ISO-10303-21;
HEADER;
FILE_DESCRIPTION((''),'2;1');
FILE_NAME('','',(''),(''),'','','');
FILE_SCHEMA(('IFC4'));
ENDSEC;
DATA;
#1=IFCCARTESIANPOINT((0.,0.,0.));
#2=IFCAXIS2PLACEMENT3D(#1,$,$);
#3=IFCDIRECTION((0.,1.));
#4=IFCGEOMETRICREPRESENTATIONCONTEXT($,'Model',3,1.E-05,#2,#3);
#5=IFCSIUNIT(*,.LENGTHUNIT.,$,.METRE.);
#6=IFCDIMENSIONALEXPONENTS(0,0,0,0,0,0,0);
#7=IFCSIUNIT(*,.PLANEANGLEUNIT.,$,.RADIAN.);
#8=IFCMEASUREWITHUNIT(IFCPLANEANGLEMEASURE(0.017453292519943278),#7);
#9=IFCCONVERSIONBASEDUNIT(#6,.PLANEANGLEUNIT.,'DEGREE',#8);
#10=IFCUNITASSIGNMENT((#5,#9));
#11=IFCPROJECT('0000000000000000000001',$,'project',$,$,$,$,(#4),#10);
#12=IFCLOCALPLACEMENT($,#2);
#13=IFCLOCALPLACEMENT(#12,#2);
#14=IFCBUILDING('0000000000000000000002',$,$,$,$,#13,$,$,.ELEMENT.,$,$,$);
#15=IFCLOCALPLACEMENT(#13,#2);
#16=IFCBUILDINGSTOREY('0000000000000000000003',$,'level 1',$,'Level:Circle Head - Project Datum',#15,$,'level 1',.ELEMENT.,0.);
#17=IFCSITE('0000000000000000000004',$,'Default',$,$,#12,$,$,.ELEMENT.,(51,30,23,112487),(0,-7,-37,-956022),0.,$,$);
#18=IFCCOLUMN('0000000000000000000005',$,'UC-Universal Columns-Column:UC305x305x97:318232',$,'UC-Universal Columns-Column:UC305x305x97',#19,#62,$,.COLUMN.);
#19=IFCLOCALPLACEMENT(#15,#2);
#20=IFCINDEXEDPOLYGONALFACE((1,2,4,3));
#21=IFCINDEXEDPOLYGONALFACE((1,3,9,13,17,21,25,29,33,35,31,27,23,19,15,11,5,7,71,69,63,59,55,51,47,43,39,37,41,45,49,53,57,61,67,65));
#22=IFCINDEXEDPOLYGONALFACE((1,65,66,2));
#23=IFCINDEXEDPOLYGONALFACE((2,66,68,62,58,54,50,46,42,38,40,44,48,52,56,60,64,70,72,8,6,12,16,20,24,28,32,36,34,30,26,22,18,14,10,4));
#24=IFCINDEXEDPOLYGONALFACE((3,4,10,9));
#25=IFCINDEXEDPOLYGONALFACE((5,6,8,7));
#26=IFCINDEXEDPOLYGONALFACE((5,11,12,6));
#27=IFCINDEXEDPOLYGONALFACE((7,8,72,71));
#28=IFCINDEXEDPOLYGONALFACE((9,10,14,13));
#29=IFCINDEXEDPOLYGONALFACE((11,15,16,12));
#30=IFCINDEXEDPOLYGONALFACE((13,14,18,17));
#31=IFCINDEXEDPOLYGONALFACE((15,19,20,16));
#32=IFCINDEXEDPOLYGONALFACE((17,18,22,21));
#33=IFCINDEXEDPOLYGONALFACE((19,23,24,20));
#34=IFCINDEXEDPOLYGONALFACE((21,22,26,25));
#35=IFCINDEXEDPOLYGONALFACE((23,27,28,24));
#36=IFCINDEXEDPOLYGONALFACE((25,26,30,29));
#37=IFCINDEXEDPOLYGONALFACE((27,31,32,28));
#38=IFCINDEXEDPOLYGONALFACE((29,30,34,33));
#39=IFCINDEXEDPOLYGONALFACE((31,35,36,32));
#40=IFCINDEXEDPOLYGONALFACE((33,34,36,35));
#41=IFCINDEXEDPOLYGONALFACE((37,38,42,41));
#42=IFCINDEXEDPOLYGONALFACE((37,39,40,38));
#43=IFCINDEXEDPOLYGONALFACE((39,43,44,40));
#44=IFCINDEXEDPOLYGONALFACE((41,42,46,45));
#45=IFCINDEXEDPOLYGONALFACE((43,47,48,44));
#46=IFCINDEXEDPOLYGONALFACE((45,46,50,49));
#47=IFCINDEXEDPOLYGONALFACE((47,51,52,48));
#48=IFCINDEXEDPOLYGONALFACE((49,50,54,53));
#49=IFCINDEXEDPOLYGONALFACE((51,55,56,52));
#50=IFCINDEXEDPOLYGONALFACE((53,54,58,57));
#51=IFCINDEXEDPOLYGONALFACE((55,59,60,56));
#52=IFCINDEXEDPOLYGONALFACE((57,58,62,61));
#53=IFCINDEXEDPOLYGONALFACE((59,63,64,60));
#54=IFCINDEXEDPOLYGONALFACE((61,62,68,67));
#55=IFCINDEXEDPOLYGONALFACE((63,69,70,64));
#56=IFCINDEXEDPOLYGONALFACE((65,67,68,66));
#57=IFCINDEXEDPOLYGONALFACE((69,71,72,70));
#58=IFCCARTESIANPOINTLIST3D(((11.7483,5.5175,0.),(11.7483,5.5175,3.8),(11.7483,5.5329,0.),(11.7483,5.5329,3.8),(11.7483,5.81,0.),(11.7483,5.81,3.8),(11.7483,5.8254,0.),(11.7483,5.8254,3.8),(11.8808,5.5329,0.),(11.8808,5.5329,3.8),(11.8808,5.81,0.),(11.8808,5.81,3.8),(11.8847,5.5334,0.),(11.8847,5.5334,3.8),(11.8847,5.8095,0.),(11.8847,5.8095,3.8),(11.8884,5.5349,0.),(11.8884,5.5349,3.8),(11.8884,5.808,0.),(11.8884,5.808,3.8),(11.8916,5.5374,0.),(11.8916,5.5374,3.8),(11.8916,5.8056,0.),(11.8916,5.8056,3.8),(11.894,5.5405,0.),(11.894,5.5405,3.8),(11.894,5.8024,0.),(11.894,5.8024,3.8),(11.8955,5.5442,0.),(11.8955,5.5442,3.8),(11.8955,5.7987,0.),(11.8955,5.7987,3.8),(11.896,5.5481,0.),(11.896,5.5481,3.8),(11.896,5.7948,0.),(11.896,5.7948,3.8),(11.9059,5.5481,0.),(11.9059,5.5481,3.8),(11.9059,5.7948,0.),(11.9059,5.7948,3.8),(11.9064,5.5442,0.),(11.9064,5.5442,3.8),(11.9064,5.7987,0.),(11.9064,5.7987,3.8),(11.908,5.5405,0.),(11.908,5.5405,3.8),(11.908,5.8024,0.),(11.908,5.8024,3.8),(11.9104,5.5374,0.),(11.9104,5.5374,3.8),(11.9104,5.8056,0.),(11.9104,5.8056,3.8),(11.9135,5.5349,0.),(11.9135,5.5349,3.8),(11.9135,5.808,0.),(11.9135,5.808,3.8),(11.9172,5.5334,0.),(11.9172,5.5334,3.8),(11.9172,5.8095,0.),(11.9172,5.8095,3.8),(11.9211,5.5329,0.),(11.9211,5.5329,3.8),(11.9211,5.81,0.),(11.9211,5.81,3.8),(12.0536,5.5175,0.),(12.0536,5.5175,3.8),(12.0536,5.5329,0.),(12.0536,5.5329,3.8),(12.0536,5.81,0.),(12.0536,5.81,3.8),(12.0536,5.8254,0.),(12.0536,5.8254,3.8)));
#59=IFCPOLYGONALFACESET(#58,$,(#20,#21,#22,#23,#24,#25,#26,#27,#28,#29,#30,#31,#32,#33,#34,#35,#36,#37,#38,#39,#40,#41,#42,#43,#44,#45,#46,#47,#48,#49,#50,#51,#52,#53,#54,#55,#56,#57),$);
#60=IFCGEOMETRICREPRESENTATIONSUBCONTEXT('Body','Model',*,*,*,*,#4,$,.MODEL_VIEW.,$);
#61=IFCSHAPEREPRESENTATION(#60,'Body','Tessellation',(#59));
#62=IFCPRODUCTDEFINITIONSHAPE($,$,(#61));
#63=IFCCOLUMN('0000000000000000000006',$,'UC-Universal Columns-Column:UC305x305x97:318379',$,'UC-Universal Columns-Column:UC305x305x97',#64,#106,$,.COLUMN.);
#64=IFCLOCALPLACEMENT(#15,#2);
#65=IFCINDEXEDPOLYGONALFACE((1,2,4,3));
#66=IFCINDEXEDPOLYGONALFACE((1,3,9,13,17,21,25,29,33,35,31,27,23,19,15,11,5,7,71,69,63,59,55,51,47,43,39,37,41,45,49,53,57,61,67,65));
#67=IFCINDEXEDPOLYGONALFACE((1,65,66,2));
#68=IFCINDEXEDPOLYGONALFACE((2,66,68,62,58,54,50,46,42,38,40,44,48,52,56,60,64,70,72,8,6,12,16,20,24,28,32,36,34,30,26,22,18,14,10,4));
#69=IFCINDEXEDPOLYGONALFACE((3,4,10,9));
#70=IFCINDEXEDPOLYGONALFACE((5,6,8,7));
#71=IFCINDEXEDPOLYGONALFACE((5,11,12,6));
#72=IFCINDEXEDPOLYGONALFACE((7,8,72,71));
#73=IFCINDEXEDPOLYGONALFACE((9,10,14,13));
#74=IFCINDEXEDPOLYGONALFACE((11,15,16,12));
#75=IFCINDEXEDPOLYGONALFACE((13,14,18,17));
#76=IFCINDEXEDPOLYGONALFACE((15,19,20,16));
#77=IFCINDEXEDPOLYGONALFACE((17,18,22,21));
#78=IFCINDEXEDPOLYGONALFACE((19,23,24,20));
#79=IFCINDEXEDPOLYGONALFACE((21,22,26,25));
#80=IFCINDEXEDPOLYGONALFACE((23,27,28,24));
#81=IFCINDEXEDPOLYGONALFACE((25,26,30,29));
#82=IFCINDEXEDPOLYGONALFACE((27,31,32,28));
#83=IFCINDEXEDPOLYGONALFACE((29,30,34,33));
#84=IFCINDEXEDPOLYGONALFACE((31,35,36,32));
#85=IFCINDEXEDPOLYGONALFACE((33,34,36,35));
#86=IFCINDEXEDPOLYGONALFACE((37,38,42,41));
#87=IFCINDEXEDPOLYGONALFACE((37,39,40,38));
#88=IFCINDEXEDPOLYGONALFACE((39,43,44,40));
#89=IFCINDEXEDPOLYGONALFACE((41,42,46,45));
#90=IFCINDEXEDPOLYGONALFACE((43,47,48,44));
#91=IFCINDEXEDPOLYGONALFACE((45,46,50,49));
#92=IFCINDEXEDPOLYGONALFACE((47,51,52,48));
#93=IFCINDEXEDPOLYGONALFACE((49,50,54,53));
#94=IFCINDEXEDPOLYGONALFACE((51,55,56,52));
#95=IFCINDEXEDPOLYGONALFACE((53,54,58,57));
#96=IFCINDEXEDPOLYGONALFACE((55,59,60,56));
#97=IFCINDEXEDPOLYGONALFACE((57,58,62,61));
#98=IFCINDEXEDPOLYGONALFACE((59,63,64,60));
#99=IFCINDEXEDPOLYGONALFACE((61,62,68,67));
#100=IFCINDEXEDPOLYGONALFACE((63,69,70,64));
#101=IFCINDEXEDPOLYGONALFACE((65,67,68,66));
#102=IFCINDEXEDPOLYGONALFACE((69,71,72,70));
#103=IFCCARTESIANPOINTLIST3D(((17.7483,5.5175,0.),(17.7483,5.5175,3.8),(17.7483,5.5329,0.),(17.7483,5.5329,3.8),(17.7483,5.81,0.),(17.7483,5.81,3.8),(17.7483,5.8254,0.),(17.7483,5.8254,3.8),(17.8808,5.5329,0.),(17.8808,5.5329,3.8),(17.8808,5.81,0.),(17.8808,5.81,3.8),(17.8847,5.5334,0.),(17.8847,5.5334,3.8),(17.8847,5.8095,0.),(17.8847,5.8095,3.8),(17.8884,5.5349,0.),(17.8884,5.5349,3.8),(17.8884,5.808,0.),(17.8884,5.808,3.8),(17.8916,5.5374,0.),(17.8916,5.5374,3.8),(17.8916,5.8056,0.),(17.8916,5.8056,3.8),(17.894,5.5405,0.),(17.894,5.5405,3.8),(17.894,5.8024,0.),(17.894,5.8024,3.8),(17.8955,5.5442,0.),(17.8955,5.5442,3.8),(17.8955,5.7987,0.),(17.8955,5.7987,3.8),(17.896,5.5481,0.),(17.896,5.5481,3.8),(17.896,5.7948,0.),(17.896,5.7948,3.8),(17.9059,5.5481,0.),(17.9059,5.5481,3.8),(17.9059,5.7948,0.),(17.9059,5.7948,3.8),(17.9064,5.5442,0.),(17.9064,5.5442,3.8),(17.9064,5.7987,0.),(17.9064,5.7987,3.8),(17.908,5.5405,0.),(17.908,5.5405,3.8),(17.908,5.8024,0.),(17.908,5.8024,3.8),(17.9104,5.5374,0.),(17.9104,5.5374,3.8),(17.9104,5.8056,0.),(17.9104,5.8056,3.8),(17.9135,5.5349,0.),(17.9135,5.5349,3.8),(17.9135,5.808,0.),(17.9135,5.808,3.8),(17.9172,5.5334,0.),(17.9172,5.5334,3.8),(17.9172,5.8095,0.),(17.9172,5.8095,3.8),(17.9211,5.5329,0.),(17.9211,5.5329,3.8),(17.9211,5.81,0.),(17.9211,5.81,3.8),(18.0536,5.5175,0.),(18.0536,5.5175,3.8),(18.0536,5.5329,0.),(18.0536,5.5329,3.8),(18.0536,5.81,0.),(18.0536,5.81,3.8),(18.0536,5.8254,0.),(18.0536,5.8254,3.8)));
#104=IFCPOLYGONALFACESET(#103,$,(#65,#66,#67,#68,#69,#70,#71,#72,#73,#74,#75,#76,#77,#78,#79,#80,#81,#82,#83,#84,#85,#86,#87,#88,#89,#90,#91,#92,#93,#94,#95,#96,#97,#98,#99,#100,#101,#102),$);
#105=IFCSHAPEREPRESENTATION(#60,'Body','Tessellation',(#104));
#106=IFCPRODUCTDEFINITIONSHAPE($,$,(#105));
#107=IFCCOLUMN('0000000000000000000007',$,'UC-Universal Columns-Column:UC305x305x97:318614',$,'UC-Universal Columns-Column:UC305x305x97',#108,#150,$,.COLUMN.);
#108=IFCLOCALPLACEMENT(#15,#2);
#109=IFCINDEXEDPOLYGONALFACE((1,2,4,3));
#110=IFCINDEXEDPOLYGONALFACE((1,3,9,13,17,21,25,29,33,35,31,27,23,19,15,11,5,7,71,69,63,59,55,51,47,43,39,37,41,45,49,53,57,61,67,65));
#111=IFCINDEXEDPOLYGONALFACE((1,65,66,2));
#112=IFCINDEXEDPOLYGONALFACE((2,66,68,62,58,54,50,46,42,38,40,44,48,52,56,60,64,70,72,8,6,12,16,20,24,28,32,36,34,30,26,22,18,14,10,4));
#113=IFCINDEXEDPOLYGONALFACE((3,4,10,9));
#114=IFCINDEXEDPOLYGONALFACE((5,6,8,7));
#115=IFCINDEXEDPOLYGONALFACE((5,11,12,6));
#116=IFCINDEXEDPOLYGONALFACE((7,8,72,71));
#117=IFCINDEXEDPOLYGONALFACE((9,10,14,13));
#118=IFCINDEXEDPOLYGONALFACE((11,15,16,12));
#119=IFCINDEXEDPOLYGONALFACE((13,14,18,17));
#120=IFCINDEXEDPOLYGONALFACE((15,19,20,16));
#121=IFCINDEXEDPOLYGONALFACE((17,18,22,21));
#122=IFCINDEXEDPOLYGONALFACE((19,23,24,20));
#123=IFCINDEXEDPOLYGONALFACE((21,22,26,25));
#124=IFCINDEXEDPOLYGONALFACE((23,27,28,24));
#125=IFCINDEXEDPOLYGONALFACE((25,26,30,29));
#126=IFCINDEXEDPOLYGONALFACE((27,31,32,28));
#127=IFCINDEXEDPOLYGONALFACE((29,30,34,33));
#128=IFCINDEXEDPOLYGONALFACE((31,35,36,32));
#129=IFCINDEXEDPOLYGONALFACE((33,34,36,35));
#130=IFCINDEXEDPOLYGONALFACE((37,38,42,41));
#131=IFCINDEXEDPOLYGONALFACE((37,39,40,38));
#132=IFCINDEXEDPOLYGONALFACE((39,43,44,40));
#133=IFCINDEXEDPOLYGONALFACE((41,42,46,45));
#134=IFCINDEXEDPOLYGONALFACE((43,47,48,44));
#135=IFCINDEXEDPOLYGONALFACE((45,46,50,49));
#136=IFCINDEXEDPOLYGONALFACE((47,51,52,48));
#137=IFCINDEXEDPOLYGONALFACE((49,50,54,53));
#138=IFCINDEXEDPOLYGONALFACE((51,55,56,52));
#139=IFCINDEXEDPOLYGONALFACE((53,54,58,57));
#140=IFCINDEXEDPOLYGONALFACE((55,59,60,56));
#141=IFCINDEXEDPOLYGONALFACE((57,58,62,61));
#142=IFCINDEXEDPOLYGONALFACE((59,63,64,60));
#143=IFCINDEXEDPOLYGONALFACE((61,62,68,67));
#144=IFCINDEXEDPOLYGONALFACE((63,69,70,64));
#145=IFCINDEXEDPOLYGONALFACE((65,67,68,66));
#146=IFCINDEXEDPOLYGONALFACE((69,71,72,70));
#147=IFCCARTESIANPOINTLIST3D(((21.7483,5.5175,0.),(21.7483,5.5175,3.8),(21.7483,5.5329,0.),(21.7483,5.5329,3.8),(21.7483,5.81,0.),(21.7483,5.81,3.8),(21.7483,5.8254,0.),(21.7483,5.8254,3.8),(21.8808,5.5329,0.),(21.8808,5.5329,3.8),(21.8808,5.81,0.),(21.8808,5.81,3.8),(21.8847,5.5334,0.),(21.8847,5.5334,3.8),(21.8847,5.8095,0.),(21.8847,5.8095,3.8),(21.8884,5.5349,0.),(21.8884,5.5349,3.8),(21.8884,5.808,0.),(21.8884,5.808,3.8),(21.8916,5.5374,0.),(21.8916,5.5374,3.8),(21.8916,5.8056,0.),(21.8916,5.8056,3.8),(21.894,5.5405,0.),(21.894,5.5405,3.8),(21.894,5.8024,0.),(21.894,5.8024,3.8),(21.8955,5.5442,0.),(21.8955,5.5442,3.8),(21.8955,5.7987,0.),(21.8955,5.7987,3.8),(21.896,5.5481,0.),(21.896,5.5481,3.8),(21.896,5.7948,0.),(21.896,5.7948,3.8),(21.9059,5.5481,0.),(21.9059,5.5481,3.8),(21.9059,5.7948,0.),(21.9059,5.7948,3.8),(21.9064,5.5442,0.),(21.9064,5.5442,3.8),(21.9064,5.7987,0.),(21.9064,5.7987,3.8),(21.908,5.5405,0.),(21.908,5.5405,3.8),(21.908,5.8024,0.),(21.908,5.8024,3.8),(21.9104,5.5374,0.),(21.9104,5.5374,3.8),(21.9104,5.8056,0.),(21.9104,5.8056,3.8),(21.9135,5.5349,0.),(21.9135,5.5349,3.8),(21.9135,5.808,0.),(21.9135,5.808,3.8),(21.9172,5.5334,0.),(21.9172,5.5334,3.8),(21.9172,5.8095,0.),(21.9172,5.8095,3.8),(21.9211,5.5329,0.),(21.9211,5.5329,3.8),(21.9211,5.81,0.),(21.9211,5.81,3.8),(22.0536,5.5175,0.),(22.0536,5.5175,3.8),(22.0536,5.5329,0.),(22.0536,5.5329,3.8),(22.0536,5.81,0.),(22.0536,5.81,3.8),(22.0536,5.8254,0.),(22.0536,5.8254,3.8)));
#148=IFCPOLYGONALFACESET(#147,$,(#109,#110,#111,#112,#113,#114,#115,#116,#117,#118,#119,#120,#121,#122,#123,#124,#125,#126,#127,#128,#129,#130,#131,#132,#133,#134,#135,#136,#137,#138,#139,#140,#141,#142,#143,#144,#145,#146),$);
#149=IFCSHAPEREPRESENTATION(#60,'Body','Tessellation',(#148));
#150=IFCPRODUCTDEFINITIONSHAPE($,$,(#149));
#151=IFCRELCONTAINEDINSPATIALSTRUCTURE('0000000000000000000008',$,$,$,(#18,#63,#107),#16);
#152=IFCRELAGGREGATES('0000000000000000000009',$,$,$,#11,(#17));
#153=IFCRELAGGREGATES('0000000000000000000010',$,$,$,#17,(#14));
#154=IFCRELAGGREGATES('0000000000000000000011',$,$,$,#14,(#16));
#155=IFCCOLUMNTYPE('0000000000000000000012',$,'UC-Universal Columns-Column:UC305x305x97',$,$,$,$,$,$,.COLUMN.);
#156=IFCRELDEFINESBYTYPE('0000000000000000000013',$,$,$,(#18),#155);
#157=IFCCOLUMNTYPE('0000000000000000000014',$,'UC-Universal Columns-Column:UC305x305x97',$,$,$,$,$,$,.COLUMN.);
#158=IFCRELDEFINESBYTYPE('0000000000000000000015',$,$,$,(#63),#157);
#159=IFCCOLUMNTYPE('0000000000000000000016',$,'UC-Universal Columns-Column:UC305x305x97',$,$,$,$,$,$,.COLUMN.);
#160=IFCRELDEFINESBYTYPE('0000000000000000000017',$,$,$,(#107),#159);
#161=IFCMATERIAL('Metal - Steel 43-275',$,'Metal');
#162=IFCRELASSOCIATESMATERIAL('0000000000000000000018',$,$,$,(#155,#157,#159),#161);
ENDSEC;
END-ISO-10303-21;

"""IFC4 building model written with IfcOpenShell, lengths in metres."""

from ifc_helpers import new_model, entity, si_unit, converted_unit, direction, frame, frame_2d, origin, place, context, subcontext, project, spatial, i_section, extrude, source, transform, mapped, material, material_profile, profile_set, type_object, type_shapes, element, save


model = new_model("IFC4")

# Units and contexts
model_context = context("Model", 3, precision=1e-05, world=origin(), true_north=direction((0.0, 1.0)))
body_context = subcontext(model_context, "Body", "Model", "MODEL_VIEW")
ifc_project = project(units=[si_unit("LENGTHUNIT", "METRE"), converted_unit("PLANEANGLEUNIT", "DEGREE", entity("IfcPlaneAngleMeasure", 0.017453292519943278), si_unit("PLANEANGLEUNIT", "RADIAN"), dimensions=[0, 0, 0, 0, 0, 0, 0])], contexts=[model_context])

# Site, building, storey
site_placement = place(None, origin())
site = spatial("IfcSite", under=ifc_project, at=site_placement, Name="Default", CompositionType="ELEMENT", RefLatitude=(51, 30, 23, 112487), RefLongitude=(0, -7, -37, -956022), RefElevation=0.0)
building_placement = place(site_placement, origin())
building = spatial("IfcBuilding", under=site, at=building_placement, CompositionType="ELEMENT")
storey_placement = place(building_placement, origin())
storey = spatial("IfcBuildingStorey", under=building, at=storey_placement, Name="level 1", ObjectType="Level:Circle Head - Project Datum", LongName="level 1", CompositionType="ELEMENT", Elevation=0.0)

# Columns
ifc_material_1 = material(Name="Metal - Steel 43-275", Category="Metal")
ifc_material_profile = material_profile(ifc_material_1, i_section(OverallWidth=0.3053, OverallDepth=0.3079, WebThickness=0.0099, FlangeThickness=0.0154, FilletRadius=0.0152, at=frame_2d((0.0, 0.0), x_axis=(1.0, 0.0))), Name="UC305x305x97")
ifc_profile_set = profile_set([ifc_material_profile], Name="UC305x305x97")
column_type_1 = type_object("IfcColumnType", Name="UC-Universal Columns-Column:UC305x305x97", PredefinedType="COLUMN", material=ifc_profile_set)
shared_shape_1 = source(origin(), body_context, "Body", "SweptSolid", [
    extrude(i_section(OverallWidth=0.3053, OverallDepth=0.3079, WebThickness=0.0099, FlangeThickness=0.0154, FilletRadius=0.0152, at=frame_2d((0.0, 0.0), x_axis=(1.0, 0.0))), frame((11.901, 5.6715, 0.0), z_axis=(0.0, 0.0, 1.0), x_axis=(-1.0, 0.0, 0.0)), (0.0, 0.0, 1.0), 3.8),
])
type_shapes(column_type_1, [shared_shape_1])
column_1_placement = place(storey_placement, origin())
element("IfcColumn", 1, at=column_1_placement, inside=storey, type_object=column_type_1, Name="UC-Universal Columns-Column:UC305x305x97:318232", ObjectType="UC-Universal Columns-Column:UC305x305x97", PredefinedType="COLUMN", context=body_context, shape_type="MappedRepresentation", body=[
    mapped(shared_shape_1, transform((0.0, 0.0, 0.0), scale=1.0)),
])
column_type_2 = type_object("IfcColumnType", Name="UC-Universal Columns-Column:UC305x305x97", PredefinedType="COLUMN", material=ifc_profile_set)
shared_shape_2 = source(origin(), body_context, "Body", "SweptSolid", [
    extrude(i_section(OverallWidth=0.3053, OverallDepth=0.3079, WebThickness=0.0099, FlangeThickness=0.0154, FilletRadius=0.0152, at=frame_2d((0.0, 0.0), x_axis=(1.0, 0.0))), frame((17.901, 5.6715, 0.0), z_axis=(0.0, 0.0, 1.0), x_axis=(-1.0, 0.0, 0.0)), (0.0, 0.0, 1.0), 3.8),
])
type_shapes(column_type_2, [shared_shape_2])
column_2_placement = place(storey_placement, origin())
element("IfcColumn", 2, at=column_2_placement, inside=storey, type_object=column_type_2, Name="UC-Universal Columns-Column:UC305x305x97:318379", ObjectType="UC-Universal Columns-Column:UC305x305x97", PredefinedType="COLUMN", context=body_context, shape_type="MappedRepresentation", body=[
    mapped(shared_shape_2, transform((0.0, 0.0, 0.0), scale=1.0)),
])
column_type_3 = type_object("IfcColumnType", Name="UC-Universal Columns-Column:UC305x305x97", PredefinedType="COLUMN", material=ifc_profile_set)
shared_shape_3 = source(origin(), body_context, "Body", "SweptSolid", [
    extrude(i_section(OverallWidth=0.3053, OverallDepth=0.3079, WebThickness=0.0099, FlangeThickness=0.0154, FilletRadius=0.0152, at=frame_2d((0.0, 0.0), x_axis=(1.0, 0.0))), frame((21.901, 5.6715, 0.0), z_axis=(0.0, 0.0, 1.0), x_axis=(-1.0, 0.0, 0.0)), (0.0, 0.0, 1.0), 3.8),
])
type_shapes(column_type_3, [shared_shape_3])
column_3_placement = place(storey_placement, origin())
element("IfcColumn", 3, at=column_3_placement, inside=storey, type_object=column_type_3, Name="UC-Universal Columns-Column:UC305x305x97:318614", ObjectType="UC-Universal Columns-Column:UC305x305x97", PredefinedType="COLUMN", context=body_context, shape_type="MappedRepresentation", body=[
    mapped(shared_shape_3, transform((0.0, 0.0, 0.0), scale=1.0)),
])

save(model, "model.ifc")
